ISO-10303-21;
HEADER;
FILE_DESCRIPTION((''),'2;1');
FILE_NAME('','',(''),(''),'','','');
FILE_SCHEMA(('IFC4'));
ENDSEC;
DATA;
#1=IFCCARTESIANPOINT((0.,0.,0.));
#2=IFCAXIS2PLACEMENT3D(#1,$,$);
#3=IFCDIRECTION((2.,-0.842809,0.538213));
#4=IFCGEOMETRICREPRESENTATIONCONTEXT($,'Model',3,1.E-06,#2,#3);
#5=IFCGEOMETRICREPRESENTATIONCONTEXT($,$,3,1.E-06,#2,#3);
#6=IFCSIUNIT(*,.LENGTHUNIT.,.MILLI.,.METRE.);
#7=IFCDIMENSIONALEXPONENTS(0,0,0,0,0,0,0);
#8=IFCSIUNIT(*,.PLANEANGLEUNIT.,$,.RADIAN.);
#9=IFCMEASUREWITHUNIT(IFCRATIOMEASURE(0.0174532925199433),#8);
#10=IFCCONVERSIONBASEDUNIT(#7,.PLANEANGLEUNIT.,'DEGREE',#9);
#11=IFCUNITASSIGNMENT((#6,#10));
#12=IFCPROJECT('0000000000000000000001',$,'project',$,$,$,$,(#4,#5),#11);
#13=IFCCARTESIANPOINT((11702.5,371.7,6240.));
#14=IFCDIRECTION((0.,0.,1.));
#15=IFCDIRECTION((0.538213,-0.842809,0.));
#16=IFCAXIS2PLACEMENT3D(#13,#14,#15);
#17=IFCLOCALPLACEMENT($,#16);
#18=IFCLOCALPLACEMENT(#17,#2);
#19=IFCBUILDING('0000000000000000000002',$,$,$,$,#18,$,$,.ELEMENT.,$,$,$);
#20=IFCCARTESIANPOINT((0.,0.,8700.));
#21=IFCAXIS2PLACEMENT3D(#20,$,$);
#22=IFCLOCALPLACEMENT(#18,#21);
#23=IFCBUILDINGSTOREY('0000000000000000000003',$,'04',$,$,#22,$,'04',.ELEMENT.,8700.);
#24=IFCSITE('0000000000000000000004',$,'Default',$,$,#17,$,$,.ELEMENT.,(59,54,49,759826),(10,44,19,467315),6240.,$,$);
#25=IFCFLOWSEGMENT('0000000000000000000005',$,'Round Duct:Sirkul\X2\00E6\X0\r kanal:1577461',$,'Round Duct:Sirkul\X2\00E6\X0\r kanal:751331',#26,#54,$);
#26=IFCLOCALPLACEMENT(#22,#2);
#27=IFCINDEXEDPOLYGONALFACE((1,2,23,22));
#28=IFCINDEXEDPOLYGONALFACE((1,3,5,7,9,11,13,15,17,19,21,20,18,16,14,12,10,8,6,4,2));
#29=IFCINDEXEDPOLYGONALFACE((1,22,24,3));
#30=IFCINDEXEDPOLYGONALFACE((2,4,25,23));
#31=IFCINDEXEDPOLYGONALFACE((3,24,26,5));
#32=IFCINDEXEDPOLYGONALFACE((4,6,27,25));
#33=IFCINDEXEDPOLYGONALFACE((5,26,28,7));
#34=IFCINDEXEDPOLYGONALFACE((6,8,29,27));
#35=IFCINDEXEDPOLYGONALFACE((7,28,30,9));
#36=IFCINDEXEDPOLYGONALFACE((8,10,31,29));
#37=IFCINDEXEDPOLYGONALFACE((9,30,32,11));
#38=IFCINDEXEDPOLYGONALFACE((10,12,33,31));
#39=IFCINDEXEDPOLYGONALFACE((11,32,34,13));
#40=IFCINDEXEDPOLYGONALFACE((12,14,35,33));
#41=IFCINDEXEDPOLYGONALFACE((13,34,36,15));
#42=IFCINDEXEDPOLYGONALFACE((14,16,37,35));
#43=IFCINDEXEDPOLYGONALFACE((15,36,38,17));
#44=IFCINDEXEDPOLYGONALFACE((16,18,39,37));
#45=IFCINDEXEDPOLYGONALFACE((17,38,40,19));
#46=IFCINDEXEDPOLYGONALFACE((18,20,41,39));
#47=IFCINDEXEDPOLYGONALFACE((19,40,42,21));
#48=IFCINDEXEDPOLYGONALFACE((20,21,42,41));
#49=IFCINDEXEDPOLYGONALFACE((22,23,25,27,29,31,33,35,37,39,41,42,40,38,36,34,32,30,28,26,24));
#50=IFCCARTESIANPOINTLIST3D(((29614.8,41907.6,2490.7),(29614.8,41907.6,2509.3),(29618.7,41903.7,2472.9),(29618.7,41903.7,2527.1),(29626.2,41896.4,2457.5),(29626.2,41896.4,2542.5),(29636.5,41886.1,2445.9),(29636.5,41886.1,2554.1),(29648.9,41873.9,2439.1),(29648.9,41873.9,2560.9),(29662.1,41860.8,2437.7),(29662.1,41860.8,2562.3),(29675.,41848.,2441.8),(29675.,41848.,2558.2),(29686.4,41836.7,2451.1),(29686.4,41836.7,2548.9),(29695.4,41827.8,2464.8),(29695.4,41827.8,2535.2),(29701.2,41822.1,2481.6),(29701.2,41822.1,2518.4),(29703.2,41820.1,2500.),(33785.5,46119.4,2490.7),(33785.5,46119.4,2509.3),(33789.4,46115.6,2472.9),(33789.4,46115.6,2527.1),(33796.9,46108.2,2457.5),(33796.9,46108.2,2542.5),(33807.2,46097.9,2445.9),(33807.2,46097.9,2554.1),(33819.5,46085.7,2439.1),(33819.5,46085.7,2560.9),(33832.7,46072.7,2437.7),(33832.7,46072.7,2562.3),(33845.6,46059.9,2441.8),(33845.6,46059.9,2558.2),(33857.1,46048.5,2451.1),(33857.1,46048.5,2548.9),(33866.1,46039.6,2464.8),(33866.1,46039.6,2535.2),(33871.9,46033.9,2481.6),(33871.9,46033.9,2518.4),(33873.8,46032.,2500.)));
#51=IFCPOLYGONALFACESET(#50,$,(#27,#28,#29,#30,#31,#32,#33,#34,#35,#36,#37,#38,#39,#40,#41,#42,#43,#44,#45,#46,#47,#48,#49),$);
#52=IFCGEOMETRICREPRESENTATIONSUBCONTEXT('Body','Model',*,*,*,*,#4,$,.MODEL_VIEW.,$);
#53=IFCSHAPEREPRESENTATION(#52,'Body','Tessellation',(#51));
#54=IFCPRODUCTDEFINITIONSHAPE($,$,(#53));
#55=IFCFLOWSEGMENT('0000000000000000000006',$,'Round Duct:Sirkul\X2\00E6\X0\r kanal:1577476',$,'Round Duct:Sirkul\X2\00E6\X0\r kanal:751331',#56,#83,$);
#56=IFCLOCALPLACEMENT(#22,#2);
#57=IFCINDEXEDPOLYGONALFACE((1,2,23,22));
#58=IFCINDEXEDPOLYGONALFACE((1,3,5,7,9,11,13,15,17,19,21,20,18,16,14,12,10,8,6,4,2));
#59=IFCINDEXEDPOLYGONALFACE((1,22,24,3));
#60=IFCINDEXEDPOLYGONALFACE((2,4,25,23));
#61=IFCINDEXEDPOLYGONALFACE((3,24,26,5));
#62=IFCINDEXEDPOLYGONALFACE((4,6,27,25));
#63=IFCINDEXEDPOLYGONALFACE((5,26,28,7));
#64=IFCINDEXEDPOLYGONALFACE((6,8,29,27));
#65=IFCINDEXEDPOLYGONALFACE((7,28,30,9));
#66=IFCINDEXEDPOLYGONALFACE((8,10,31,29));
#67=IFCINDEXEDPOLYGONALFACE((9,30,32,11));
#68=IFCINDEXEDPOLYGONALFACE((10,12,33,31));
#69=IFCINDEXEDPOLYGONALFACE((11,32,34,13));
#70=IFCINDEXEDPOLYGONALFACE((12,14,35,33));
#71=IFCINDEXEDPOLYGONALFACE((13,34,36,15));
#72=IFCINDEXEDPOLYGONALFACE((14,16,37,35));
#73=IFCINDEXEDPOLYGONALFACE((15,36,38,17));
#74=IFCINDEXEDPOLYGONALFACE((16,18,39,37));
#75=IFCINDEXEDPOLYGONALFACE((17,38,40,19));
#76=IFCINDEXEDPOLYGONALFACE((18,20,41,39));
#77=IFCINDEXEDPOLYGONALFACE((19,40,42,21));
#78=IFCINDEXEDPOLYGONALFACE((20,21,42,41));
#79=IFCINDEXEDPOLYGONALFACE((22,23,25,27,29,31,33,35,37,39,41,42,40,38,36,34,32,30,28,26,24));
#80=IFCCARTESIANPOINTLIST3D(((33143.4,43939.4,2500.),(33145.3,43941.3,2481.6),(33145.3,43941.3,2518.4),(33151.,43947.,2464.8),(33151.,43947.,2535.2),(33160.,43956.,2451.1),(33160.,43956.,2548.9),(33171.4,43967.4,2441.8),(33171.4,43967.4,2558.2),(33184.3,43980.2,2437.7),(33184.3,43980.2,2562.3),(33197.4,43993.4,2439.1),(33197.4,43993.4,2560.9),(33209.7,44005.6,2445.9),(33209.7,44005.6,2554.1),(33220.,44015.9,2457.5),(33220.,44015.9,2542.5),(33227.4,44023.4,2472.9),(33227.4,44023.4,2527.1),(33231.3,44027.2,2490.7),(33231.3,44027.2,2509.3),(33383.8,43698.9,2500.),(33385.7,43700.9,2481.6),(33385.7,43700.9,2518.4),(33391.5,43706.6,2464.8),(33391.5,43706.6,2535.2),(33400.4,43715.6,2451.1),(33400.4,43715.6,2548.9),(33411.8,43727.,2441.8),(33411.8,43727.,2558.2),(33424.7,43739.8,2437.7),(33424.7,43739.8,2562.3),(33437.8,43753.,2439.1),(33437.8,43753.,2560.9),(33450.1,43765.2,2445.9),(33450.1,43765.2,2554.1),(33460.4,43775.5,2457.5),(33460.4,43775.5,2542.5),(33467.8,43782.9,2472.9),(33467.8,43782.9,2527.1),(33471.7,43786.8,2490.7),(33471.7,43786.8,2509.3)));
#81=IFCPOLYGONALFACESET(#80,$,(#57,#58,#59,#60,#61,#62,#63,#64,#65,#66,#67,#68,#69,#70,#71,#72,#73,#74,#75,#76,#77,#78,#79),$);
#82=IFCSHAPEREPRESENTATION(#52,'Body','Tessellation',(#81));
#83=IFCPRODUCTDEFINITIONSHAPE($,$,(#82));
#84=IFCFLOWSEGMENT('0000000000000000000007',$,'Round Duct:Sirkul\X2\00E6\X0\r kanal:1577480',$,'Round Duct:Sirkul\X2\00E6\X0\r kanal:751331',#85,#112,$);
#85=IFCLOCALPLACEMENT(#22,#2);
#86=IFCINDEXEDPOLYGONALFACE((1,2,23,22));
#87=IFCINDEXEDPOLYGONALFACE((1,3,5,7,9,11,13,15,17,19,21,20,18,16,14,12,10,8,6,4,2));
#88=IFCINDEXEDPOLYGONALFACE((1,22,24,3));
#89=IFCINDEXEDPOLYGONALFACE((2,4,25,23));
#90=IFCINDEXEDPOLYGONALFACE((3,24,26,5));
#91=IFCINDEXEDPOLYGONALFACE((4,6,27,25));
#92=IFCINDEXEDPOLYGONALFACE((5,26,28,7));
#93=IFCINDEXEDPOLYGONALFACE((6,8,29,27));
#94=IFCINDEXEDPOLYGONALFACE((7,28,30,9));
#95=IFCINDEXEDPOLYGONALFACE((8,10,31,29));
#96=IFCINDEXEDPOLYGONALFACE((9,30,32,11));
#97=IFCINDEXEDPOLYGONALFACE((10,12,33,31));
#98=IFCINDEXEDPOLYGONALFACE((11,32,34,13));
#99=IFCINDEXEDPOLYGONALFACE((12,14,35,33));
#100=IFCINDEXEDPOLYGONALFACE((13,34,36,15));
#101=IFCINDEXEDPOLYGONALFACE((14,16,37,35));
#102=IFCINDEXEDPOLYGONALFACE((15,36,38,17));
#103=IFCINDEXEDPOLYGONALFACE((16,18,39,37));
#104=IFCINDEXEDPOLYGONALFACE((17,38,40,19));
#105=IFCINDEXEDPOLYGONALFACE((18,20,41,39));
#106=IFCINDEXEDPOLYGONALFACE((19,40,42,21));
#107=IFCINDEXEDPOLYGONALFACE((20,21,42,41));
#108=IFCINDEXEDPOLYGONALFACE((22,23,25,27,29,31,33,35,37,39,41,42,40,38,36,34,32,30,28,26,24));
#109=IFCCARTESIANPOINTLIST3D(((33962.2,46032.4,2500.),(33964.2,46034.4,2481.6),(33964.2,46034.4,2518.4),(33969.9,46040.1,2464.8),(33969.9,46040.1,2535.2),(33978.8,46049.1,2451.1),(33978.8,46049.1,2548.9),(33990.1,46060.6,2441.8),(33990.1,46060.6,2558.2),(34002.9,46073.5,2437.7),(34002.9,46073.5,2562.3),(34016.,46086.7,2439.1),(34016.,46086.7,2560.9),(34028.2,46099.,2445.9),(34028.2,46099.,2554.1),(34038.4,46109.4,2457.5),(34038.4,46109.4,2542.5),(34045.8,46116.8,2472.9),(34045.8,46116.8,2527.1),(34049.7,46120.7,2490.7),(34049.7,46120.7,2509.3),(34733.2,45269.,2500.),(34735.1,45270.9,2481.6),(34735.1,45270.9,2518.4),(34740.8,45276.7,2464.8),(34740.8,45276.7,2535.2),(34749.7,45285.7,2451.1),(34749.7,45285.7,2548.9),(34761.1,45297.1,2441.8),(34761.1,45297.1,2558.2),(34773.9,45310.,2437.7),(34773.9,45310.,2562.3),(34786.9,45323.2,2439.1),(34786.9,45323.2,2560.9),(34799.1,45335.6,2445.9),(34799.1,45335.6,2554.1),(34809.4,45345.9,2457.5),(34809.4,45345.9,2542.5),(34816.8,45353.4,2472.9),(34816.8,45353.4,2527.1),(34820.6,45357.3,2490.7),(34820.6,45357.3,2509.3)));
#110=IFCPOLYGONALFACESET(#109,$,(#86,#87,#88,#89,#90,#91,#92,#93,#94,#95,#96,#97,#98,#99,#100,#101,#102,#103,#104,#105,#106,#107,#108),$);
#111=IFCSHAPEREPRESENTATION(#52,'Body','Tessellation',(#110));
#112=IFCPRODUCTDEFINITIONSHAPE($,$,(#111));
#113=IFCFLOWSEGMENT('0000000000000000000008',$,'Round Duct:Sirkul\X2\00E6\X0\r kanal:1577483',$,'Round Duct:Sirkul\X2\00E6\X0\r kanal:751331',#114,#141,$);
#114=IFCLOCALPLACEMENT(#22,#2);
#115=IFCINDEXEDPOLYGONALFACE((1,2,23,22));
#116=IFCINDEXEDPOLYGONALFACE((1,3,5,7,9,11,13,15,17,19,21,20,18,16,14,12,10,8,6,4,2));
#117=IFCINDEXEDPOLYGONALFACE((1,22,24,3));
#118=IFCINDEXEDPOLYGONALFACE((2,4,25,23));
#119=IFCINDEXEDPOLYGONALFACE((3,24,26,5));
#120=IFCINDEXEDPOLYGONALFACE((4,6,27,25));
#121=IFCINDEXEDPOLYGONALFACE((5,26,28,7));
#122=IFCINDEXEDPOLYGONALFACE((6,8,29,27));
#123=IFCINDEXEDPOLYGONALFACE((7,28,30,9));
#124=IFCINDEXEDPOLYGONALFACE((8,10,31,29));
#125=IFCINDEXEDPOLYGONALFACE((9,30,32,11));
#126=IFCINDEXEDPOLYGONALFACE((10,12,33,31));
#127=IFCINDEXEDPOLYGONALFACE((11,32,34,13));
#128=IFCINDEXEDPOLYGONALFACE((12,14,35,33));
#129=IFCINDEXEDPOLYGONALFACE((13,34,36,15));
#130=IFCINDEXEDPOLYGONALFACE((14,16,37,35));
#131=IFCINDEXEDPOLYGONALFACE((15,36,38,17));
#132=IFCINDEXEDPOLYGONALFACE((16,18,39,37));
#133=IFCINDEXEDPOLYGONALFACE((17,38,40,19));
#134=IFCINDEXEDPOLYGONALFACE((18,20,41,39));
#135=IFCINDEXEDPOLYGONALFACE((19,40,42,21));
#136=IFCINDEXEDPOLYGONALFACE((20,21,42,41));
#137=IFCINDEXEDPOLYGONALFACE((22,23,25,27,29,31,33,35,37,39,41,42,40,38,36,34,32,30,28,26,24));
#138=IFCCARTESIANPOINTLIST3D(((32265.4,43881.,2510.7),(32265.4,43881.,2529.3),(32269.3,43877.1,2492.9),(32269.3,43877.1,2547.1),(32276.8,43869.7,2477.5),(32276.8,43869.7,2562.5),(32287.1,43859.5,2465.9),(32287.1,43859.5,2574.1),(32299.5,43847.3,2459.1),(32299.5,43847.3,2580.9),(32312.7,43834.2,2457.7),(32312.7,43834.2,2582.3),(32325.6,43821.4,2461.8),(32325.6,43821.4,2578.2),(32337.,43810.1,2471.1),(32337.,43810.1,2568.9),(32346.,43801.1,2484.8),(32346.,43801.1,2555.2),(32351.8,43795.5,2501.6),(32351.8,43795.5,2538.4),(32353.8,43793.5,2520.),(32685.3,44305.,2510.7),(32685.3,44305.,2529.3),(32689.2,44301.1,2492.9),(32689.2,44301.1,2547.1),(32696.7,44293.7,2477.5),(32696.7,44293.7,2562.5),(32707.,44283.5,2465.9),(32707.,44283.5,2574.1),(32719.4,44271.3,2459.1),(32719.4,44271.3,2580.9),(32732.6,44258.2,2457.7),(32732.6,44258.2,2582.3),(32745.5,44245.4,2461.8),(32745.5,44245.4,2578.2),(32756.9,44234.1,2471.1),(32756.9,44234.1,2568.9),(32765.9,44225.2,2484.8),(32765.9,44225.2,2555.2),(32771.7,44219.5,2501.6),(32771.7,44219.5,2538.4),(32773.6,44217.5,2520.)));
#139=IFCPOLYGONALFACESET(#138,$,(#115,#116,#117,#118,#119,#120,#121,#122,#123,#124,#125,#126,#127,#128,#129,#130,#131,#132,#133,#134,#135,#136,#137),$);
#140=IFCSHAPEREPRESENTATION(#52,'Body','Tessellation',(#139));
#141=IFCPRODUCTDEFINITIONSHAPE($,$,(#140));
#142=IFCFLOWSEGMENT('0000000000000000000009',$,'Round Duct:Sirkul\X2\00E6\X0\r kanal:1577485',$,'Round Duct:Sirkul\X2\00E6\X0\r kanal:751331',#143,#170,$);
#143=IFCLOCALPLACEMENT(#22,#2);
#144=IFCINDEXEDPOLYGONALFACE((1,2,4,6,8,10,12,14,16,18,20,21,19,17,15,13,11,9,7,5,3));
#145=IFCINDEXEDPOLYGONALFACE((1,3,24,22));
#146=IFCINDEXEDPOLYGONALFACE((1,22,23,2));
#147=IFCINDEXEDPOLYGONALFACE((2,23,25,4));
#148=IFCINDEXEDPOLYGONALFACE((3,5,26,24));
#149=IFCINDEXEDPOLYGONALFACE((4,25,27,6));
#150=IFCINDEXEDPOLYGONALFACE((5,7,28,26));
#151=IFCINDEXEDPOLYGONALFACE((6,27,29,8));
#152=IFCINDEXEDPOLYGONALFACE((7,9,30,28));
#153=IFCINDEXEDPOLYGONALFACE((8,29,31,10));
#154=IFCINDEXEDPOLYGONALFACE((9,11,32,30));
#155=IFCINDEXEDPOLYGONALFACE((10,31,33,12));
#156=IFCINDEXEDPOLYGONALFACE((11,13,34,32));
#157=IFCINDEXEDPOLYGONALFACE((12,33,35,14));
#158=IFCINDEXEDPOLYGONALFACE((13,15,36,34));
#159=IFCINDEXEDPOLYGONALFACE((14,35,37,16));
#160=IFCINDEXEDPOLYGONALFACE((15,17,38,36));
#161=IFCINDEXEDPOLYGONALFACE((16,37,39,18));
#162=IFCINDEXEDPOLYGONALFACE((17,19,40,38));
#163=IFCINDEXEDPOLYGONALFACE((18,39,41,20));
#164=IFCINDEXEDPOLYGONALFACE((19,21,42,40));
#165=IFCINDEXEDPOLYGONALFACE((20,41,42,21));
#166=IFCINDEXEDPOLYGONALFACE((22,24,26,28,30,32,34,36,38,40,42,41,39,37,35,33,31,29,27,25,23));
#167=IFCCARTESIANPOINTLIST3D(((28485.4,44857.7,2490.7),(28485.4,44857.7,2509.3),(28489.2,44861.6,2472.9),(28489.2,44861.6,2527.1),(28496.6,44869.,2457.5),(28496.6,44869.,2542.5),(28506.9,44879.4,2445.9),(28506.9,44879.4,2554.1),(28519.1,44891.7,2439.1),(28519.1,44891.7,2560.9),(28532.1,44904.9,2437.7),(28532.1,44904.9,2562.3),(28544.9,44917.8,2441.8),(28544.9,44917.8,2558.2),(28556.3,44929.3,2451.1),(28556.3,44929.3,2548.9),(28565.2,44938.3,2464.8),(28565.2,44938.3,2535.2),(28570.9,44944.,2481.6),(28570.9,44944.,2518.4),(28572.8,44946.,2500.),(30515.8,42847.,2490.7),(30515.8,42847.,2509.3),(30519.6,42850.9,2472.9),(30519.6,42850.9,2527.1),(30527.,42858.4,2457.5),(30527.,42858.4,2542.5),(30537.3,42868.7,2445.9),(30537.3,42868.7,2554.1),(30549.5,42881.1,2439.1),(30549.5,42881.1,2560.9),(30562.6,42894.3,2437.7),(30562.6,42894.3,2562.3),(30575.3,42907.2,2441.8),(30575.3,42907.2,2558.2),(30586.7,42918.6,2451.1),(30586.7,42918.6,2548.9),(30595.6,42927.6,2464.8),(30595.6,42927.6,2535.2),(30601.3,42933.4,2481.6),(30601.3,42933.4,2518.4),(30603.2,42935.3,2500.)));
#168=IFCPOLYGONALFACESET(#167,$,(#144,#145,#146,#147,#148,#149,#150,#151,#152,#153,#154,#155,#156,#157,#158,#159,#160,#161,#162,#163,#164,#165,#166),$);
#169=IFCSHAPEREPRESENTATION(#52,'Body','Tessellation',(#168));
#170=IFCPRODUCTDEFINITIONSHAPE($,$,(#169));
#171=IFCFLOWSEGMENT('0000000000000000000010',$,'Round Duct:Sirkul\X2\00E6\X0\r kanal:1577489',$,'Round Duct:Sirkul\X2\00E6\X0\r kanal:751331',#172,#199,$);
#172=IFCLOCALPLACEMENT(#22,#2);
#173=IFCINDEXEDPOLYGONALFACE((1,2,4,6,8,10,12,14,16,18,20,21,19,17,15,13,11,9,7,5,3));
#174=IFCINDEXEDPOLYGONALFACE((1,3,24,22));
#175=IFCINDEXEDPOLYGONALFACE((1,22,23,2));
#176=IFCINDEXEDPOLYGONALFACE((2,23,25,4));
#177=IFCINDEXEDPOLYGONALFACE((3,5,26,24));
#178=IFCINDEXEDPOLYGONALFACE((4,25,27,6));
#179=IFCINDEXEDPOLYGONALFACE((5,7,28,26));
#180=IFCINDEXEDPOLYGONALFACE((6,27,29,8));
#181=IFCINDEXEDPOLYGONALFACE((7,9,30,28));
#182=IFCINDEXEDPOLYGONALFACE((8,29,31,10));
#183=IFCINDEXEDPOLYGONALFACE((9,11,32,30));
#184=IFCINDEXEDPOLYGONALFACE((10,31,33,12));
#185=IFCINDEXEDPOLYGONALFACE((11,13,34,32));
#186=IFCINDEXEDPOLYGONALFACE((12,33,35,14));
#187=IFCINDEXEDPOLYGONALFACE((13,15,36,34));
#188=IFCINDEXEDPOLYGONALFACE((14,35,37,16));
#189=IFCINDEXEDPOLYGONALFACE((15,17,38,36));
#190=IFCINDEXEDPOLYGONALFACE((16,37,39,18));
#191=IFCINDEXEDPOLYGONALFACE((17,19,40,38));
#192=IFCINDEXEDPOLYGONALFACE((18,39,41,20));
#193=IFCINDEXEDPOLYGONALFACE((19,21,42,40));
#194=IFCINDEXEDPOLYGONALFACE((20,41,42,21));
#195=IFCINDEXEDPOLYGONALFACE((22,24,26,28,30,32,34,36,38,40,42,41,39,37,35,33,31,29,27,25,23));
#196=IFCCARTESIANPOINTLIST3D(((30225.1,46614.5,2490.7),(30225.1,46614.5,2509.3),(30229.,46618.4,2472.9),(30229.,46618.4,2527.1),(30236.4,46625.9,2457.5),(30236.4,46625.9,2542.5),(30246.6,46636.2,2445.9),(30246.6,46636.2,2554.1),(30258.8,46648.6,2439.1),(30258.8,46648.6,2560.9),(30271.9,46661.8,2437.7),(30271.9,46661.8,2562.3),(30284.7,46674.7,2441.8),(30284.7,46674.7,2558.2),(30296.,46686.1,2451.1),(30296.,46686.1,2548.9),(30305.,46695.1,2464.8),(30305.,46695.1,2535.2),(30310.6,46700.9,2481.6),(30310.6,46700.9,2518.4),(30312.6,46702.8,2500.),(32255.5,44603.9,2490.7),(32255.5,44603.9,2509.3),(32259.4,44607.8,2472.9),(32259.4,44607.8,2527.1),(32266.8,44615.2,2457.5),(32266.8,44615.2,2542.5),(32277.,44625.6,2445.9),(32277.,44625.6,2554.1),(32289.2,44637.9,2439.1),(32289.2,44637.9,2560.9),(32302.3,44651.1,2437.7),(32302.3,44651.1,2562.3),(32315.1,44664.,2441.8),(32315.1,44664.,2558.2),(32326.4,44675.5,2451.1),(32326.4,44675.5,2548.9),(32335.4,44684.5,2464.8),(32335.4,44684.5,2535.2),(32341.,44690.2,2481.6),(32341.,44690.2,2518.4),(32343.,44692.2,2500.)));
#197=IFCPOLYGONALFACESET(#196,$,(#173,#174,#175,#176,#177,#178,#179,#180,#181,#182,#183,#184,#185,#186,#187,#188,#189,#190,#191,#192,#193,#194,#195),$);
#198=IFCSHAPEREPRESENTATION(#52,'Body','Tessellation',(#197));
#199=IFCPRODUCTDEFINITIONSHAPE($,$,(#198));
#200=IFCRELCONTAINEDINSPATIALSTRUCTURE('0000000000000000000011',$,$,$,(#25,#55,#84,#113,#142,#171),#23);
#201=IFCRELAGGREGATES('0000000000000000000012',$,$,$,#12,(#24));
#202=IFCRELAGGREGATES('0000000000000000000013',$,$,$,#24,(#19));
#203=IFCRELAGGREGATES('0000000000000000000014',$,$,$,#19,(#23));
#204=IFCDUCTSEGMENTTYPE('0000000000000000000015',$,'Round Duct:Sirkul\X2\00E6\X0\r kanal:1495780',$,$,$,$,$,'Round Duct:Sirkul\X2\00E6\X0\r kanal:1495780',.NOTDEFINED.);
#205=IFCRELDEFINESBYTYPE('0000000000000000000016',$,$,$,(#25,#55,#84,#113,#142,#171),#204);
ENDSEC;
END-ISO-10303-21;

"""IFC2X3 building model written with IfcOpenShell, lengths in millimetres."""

from ifc_helpers import new_model, entity, si_unit, converted_unit, direction, frame, origin, origin_2d_with_axis, place, context, subcontext, project, spatial, circle, extrude, type_object, element, save


model = new_model("IFC2X3")

# Units and contexts
model_context = context("Model", 3, precision=1e-06, world=origin(), true_north=direction((2.0, -0.842809, 0.538213)))
context_of_model = context(None, 3, precision=1e-06, world=origin(), true_north=direction((2.0, -0.842809, 0.538213)))
body_context = subcontext(model_context, "Body", "Model", "MODEL_VIEW")
ifc_project = project(units=[si_unit("LENGTHUNIT", "METRE", prefix="MILLI"), converted_unit("PLANEANGLEUNIT", "DEGREE", entity("IfcRatioMeasure", 0.0174532925199433), si_unit("PLANEANGLEUNIT", "RADIAN"), dimensions=[0, 0, 0, 0, 0, 0, 0])], contexts=[model_context, context_of_model])

# Site, building, storey
site_placement = place(None, frame((11702.5, 371.7, 6240.0), z_axis=(0.0, 0.0, 1.0), x_axis=(0.538213, -0.842809, 0.0)))
site = spatial("IfcSite", under=ifc_project, at=site_placement, Name="Default", CompositionType="ELEMENT", RefLatitude=(59, 54, 49, 759826), RefLongitude=(10, 44, 19, 467315), RefElevation=6240.0)
building_placement = place(site_placement, origin())
building = spatial("IfcBuilding", under=site, at=building_placement, CompositionType="ELEMENT")
storey_placement = place(building_placement, frame((0.0, 0.0, 8700.0)))
storey = spatial("IfcBuildingStorey", under=building, at=storey_placement, Name="04", LongName="04", CompositionType="ELEMENT", Elevation=8700.0)

# Flow segments
duct_segment_type = type_object("IfcDuctSegmentType", Name="Round Duct:Sirkulær kanal:1495780", ElementType="Round Duct:Sirkulær kanal:1495780", PredefinedType="NOTDEFINED")
flow_segment_1_placement = place(storey_placement, origin())
element("IfcFlowSegment", 1, at=flow_segment_1_placement, inside=storey, type_object=duct_segment_type, Name="Round Duct:Sirkulær kanal:1577461", ObjectType="Round Duct:Sirkulær kanal:751331", context=body_context, shape_type="SweptSolid", body=[
    extrude(circle(Radius=62.5, at=origin_2d_with_axis()), frame((29658.8, 41864.1, 2500.0), z_axis=(0.703625, 0.710572, 0.0), x_axis=(0.710572, -0.703625, 0.0)), (0.0, 0.0, 1.0), 5927.4),
])
flow_segment_2_placement = place(storey_placement, origin())
element("IfcFlowSegment", 2, at=flow_segment_2_placement, inside=storey, type_object=duct_segment_type, Name="Round Duct:Sirkulær kanal:1577476", ObjectType="Round Duct:Sirkulær kanal:751331", context=body_context, shape_type="SweptSolid", body=[
    extrude(circle(Radius=62.5, at=origin_2d_with_axis()), frame((33187.6, 43983.5, 2500.0), z_axis=(0.707107, -0.707107, 0.0), x_axis=(-0.707107, -0.707107, 0.0)), (0.0, 0.0, 1.0), 340.0),
])
flow_segment_3_placement = place(storey_placement, origin())
element("IfcFlowSegment", 3, at=flow_segment_3_placement, inside=storey, type_object=duct_segment_type, Name="Round Duct:Sirkulær kanal:1577480", ObjectType="Round Duct:Sirkulær kanal:751331", context=body_context, shape_type="SweptSolid", body=[
    extrude(circle(Radius=62.5, at=origin_2d_with_axis()), frame((34006.2, 46076.8, 2500.0), z_axis=(0.710554, -0.703643, 0.0), x_axis=(-0.703643, -0.710554, 0.0)), (0.0, 0.0, 1.0), 1085.0),
])
flow_segment_4_placement = place(storey_placement, origin())
element("IfcFlowSegment", 4, at=flow_segment_4_placement, inside=storey, type_object=duct_segment_type, Name="Round Duct:Sirkulær kanal:1577483", ObjectType="Round Duct:Sirkulær kanal:751331", context=body_context, shape_type="SweptSolid", body=[
    extrude(circle(Radius=62.5, at=origin_2d_with_axis()), frame((32309.4, 43837.5, 2520.0), z_axis=(0.703643, 0.710554, 0.0), x_axis=(0.710554, -0.703643, 0.0)), (0.0, 0.0, 1.0), 596.7),
])
flow_segment_5_placement = place(storey_placement, origin())
element("IfcFlowSegment", 5, at=flow_segment_5_placement, inside=storey, type_object=duct_segment_type, Name="Round Duct:Sirkulær kanal:1577485", ObjectType="Round Duct:Sirkulær kanal:751331", context=body_context, shape_type="SweptSolid", body=[
    extrude(circle(Radius=62.5, at=origin_2d_with_axis()), frame((30559.3, 42890.9, 2500.0), z_axis=(-0.710554, 0.703643, 0.0), x_axis=(0.703643, 0.710554, 0.0)), (0.0, 0.0, 1.0), 2857.5),
])
flow_segment_6_placement = place(storey_placement, origin())
element("IfcFlowSegment", 6, at=flow_segment_6_placement, inside=storey, type_object=duct_segment_type, Name="Round Duct:Sirkulær kanal:1577489", ObjectType="Round Duct:Sirkulær kanal:751331", context=body_context, shape_type="SweptSolid", body=[
    extrude(circle(Radius=62.5, at=origin_2d_with_axis()), frame((32299.0, 44647.8, 2500.0), z_axis=(-0.710554, 0.703643, 0.0), x_axis=(0.703643, 0.710554, 0.0)), (0.0, 0.0, 1.0), 2857.5),
])

save(model, "model.ifc")
